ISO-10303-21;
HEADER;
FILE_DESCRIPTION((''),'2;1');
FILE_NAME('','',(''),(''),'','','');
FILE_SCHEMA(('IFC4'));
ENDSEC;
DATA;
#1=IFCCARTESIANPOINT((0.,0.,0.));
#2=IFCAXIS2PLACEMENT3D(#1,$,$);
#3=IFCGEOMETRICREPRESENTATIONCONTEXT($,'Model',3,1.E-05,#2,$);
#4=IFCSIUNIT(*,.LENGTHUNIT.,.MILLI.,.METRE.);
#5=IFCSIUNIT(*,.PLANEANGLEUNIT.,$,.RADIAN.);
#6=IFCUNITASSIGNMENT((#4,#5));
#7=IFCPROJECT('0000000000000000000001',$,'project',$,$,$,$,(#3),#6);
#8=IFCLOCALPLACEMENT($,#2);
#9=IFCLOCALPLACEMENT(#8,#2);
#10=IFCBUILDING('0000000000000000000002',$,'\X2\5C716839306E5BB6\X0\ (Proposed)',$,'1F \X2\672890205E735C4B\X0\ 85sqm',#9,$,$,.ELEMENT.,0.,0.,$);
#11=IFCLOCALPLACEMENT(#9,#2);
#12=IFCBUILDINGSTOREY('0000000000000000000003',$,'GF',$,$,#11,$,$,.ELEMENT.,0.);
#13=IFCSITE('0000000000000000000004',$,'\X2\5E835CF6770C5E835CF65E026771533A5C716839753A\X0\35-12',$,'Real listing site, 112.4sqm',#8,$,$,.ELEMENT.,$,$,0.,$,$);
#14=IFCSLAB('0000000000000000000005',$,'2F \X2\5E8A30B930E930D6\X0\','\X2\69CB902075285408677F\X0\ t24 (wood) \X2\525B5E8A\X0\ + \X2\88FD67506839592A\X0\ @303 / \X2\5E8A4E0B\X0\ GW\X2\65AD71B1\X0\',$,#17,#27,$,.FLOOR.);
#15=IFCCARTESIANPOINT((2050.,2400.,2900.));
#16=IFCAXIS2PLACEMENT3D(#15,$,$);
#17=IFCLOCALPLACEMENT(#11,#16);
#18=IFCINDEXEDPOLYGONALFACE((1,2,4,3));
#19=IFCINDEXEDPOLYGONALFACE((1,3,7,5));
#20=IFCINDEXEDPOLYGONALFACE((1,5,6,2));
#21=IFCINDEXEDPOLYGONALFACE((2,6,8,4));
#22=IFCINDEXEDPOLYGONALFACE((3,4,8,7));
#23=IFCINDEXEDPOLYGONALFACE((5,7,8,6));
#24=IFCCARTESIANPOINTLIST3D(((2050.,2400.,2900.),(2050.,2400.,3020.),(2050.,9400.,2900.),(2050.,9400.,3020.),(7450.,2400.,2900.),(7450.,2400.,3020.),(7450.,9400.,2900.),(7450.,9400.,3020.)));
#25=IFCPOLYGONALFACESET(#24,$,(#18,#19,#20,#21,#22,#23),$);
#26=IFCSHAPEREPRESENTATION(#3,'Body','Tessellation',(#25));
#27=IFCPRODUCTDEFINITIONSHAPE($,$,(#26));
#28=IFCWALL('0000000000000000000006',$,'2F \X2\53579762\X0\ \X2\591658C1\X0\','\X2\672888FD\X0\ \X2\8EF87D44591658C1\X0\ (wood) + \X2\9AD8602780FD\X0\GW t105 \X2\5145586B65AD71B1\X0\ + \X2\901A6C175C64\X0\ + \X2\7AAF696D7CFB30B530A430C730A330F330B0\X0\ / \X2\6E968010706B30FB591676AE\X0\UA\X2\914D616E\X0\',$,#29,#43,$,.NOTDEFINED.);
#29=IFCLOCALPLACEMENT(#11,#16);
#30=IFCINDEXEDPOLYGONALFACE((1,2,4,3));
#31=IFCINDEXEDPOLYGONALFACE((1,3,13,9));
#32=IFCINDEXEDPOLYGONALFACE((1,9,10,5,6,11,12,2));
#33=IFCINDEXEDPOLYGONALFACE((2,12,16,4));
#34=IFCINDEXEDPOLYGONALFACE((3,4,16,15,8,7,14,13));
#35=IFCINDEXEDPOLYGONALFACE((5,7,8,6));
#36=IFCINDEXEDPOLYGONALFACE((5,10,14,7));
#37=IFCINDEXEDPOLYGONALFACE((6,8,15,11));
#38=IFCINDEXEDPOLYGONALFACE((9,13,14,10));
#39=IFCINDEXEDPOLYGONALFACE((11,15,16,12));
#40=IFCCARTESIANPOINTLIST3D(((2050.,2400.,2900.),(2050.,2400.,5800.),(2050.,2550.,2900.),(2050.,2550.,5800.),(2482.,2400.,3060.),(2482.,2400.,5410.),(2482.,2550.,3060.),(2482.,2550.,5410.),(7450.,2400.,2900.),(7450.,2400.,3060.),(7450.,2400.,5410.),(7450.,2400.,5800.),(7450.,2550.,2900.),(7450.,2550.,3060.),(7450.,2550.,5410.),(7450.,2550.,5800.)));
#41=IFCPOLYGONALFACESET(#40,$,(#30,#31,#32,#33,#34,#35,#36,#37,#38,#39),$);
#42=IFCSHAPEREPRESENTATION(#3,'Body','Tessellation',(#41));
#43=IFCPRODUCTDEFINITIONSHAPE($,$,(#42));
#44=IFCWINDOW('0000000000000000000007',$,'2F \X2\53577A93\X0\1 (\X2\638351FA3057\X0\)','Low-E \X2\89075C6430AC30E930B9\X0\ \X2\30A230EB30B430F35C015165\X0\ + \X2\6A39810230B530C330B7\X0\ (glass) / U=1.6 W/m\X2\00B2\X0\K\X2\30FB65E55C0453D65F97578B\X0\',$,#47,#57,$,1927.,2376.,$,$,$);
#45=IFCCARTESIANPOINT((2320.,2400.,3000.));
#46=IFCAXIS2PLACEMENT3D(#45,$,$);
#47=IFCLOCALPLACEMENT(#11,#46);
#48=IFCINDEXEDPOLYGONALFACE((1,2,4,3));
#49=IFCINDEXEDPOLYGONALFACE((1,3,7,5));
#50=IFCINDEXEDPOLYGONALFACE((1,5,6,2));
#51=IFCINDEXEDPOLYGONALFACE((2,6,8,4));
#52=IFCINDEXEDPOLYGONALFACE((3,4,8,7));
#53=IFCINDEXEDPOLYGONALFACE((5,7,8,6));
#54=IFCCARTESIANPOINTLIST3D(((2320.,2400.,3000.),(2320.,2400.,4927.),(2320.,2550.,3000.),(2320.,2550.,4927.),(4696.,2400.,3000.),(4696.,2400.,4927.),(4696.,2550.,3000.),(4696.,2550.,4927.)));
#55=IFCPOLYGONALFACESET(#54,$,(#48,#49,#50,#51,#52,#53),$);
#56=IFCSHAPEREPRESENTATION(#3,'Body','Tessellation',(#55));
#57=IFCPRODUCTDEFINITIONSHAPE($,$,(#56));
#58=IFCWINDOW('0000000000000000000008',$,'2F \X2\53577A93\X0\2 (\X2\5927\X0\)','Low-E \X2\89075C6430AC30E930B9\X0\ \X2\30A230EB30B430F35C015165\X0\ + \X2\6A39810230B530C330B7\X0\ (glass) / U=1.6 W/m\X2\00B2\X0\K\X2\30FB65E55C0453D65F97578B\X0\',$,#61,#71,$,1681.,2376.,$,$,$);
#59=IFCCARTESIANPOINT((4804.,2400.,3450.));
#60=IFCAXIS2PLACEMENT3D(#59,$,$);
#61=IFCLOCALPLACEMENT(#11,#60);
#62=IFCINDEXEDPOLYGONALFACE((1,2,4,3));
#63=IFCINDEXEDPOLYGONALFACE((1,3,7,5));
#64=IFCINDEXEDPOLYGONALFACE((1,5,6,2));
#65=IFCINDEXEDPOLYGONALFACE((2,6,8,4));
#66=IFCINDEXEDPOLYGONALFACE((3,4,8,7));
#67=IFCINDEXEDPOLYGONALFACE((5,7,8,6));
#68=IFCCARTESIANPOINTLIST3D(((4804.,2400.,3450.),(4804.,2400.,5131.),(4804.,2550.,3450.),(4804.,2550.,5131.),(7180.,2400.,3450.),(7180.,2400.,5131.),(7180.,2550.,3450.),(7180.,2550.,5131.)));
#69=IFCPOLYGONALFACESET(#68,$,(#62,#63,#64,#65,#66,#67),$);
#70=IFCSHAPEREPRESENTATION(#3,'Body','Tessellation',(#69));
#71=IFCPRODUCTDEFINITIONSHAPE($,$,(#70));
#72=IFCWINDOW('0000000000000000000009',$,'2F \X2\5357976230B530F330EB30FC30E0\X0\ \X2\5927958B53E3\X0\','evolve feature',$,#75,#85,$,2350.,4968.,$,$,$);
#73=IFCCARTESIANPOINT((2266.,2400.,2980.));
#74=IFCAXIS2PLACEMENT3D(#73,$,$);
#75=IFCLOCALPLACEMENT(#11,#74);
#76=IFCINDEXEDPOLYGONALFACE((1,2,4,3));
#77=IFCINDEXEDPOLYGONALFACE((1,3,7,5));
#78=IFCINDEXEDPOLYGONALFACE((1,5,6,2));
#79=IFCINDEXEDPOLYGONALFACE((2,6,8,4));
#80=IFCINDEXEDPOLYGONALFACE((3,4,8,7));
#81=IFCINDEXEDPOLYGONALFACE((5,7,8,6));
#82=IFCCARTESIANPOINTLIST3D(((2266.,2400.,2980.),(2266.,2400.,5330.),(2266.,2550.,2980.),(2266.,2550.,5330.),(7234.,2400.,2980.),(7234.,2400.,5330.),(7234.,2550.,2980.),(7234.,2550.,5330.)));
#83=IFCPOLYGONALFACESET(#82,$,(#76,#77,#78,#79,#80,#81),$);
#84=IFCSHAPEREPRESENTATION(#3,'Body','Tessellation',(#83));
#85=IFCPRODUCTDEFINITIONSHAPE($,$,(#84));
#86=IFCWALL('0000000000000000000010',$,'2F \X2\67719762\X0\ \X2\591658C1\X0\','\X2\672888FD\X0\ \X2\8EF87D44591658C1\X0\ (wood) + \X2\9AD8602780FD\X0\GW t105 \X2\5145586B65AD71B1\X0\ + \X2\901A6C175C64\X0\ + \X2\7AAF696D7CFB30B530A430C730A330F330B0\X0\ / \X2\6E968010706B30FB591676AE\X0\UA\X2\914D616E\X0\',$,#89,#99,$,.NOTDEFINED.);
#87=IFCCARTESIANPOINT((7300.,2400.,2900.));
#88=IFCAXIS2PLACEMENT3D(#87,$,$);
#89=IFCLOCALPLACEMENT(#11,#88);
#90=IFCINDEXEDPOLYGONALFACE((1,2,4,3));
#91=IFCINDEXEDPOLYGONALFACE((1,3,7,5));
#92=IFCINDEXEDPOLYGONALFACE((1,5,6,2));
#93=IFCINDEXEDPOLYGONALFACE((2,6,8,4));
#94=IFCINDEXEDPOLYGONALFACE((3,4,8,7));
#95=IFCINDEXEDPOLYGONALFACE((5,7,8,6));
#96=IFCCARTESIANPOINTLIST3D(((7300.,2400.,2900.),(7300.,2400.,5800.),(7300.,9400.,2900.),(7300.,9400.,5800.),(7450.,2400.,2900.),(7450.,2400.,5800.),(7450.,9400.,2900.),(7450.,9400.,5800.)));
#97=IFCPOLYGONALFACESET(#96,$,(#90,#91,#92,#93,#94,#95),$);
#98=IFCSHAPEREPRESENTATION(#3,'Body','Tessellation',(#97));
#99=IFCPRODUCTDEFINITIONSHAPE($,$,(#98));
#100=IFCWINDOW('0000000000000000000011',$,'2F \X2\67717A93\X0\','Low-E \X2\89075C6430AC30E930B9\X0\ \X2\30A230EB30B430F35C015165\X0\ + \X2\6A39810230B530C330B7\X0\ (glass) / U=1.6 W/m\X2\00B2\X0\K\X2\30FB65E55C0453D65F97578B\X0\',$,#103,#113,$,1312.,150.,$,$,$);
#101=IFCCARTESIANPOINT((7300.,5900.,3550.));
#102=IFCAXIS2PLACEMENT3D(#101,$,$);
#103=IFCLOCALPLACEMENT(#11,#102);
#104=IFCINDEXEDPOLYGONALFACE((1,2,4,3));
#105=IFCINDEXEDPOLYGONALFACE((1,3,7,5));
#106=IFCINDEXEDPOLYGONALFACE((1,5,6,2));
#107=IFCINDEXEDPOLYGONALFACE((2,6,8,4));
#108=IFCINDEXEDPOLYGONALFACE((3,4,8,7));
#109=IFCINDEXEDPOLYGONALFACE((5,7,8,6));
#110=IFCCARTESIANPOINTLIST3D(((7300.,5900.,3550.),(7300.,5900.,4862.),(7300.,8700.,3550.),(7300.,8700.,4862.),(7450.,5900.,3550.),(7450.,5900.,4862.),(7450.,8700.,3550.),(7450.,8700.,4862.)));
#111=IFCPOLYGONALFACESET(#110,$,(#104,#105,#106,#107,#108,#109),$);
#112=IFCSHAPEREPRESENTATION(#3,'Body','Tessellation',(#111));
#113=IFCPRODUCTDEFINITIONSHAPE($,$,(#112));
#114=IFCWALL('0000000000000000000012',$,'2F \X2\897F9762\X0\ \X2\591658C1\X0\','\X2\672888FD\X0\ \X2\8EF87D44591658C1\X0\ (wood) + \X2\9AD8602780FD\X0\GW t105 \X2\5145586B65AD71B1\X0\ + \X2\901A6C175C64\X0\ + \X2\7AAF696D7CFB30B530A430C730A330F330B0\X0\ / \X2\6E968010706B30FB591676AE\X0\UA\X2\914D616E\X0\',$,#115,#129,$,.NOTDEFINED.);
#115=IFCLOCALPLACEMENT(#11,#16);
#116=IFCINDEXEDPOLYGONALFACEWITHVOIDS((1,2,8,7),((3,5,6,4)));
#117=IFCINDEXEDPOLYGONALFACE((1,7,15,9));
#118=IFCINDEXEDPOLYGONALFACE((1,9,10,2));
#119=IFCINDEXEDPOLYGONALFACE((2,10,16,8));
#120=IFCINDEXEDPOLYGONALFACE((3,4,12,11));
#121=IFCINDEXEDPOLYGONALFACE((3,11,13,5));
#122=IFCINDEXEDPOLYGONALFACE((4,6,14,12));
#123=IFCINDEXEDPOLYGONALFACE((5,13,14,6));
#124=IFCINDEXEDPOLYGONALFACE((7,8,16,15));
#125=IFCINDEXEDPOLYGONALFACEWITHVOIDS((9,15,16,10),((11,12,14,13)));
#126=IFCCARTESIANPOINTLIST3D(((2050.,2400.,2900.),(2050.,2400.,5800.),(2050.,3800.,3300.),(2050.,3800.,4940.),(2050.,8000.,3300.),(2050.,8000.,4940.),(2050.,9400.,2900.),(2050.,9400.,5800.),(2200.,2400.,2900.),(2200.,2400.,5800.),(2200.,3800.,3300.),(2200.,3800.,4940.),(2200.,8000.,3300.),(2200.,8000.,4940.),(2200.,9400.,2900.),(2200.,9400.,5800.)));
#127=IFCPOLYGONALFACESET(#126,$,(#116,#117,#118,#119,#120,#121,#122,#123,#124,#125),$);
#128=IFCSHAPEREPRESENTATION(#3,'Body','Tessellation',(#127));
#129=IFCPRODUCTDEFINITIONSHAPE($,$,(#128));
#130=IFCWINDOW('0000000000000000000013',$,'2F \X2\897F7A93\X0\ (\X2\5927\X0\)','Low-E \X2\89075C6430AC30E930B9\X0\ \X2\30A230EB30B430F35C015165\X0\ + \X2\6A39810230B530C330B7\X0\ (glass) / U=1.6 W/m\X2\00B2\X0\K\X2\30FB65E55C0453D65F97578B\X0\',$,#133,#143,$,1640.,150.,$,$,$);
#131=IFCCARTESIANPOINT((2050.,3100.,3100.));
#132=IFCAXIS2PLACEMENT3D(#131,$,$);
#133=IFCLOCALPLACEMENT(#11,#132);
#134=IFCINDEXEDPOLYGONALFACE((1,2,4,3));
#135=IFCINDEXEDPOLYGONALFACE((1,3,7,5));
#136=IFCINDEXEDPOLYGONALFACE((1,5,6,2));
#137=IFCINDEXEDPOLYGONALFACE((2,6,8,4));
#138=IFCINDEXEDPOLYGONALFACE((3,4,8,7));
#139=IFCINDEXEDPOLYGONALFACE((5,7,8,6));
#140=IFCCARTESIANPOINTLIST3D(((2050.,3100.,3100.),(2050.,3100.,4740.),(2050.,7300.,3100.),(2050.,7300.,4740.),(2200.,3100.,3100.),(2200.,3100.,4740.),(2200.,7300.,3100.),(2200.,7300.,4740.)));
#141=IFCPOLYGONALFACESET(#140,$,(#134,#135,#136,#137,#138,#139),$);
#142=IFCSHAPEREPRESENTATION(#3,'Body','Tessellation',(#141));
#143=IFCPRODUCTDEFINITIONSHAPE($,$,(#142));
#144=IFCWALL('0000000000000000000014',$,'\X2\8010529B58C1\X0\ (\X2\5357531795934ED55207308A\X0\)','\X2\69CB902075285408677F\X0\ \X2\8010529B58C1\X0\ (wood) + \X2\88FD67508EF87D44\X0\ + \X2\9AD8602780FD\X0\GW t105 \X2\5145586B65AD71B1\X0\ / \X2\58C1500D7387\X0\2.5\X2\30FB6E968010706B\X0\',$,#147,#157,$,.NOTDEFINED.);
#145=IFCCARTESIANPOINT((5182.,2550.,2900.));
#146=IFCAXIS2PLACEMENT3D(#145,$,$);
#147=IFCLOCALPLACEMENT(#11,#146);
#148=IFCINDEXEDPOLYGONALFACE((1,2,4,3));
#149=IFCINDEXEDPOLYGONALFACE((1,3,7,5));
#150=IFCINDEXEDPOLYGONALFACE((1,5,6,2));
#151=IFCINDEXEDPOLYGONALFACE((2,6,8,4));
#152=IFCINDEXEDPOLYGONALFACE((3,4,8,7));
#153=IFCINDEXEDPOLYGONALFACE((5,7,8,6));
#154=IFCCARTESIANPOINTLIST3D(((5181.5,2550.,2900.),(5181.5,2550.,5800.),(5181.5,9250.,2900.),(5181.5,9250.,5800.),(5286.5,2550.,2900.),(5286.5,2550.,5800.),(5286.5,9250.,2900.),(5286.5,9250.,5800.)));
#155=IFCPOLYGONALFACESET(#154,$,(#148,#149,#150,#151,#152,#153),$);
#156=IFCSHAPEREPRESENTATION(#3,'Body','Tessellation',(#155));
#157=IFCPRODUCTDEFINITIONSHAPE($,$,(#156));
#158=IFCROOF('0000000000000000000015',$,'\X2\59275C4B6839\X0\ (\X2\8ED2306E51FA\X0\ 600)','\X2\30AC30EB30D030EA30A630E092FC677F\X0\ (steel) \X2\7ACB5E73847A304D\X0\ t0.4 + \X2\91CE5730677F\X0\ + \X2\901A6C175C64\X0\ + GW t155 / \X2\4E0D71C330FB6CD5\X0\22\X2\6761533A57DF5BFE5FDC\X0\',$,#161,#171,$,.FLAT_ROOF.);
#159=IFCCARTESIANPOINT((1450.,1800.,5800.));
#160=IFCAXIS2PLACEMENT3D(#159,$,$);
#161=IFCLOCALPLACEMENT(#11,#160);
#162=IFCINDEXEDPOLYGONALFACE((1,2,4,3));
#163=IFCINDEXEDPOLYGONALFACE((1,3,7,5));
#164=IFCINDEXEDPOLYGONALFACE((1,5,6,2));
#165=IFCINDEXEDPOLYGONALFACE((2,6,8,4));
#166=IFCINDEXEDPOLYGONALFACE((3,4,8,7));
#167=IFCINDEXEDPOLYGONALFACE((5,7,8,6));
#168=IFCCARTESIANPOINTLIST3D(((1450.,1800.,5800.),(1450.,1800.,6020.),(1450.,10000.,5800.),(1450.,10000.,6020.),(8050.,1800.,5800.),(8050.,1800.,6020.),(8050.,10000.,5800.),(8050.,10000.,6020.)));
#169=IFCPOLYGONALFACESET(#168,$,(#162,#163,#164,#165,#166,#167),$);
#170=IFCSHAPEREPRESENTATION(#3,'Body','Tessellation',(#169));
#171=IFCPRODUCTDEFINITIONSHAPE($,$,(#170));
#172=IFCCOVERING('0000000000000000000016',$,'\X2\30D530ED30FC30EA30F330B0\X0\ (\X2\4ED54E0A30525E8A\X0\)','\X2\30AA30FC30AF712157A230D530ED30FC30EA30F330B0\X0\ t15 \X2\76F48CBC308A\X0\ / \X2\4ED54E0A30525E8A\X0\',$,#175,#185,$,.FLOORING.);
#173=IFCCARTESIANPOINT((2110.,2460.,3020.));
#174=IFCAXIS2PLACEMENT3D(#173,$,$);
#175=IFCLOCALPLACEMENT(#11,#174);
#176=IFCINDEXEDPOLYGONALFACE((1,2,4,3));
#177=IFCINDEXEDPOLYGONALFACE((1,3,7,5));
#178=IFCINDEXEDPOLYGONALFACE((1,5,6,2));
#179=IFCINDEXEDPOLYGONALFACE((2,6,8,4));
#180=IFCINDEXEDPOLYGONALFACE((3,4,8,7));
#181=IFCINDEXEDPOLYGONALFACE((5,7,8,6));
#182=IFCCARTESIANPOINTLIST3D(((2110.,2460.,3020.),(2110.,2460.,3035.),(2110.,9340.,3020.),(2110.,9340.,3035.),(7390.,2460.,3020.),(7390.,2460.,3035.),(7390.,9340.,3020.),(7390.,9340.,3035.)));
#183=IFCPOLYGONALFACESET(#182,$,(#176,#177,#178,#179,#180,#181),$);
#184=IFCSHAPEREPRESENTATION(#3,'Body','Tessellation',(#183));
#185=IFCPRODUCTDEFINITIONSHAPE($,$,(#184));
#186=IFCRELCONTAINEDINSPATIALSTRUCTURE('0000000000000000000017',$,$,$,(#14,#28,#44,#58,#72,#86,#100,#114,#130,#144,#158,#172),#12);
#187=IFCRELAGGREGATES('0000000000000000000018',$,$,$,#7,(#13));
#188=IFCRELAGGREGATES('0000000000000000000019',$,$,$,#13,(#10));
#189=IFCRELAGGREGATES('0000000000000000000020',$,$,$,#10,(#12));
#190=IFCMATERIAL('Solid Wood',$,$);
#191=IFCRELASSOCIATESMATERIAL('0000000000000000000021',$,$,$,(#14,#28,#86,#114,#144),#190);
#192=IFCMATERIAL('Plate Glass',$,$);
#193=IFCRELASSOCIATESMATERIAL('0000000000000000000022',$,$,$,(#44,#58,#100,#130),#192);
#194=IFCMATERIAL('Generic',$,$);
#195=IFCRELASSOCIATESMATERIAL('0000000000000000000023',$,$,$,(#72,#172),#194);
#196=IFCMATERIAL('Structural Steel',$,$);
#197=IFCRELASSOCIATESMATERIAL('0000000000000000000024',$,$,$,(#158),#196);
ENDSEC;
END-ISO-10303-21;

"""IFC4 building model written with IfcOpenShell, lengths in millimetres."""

from ifc_helpers import new_model, si_unit, frame, frame_2d, origin, place, context, project, spatial, rectangle, extrude, material, element, fill, save


model = new_model("IFC4")

# Units and contexts
model_context = context("Model", 3, precision=1e-05, world=origin())
ifc_project = project(units=[si_unit("LENGTHUNIT", "METRE", prefix="MILLI"), si_unit("PLANEANGLEUNIT", "RADIAN")], contexts=[model_context])

# Site, building, storey
site_placement = place(None, origin())
site = spatial("IfcSite", under=ifc_project, at=site_placement, Name="広島県広島市東区山根町35-12", ObjectType="Real listing site, 112.4sqm", CompositionType="ELEMENT", RefElevation=0.0)
building_placement = place(site_placement, origin())
building = spatial("IfcBuilding", under=site, at=building_placement, Name="山根の家 (Proposed)", ObjectType="1F 木造平屋 85sqm", CompositionType="ELEMENT", ElevationOfRefHeight=0.0, ElevationOfTerrain=0.0)
storey_placement = place(building_placement, origin())
storey = spatial("IfcBuildingStorey", under=building, at=storey_placement, Name="GF", CompositionType="ELEMENT", Elevation=0.0)

# Slab
ifc_material_1 = material(Name="Solid Wood")
slab_placement = place(storey_placement, frame((2050.0, 2400.0, 2900.0)))
element("IfcSlab", 1, at=slab_placement, inside=storey, material=ifc_material_1, Name="2F 床スラブ", Description="構造用合板 t24 (wood) 剛床 + 製材根太 @303 / 床下 GW断熱", PredefinedType="FLOOR", context=model_context, shape_type="SweptSolid", body=[
    extrude(rectangle(XDim=5400.0, YDim=7000.0, at=frame_2d((2700.0, 3500.0))), frame((2050.0, 2400.0, 2900.0)), (0.0, 0.0, 1.0), 120.0),
])

# Wall, openings, windows
wall_1_placement = place(storey_placement, frame((2050.0, 2400.0, 2900.0)))
wall_1 = element("IfcWall", 2, at=wall_1_placement, inside=storey, material=ifc_material_1, Name="2F 南面 外壁", Description="木製 軸組外壁 (wood) + 高性能GW t105 充填断熱 + 通気層 + 窯業系サイディング / 準耐火・外皮UA配慮", PredefinedType="NOTDEFINED", context=model_context, shape_type="SweptSolid", body=[
    extrude(rectangle(XDim=5400.0, YDim=150.0, at=frame_2d((2700.0, 75.0))), frame((2050.0, 2400.0, 2900.0)), (0.0, 0.0, 1.0), 2900.0),
])
opening_1_placement = place(storey_placement, frame((2320.0, 2400.0, 3000.0)))
opening_1 = element("IfcOpeningElement", 3, at=opening_1_placement, cuts=wall_1, PredefinedType="NOTDEFINED", context=model_context, shape_type="SweptSolid", body=[
    extrude(rectangle(XDim=2376.0, YDim=150.0, at=frame_2d((1188.0, 75.0))), frame((2320.0, 2400.0, 3000.0)), (0.0, 0.0, 1.0), 1927.0),
])
opening_2_placement = place(storey_placement, frame((4804.0, 2400.0, 3450.0)))
opening_2 = element("IfcOpeningElement", 4, at=opening_2_placement, cuts=wall_1, PredefinedType="NOTDEFINED", context=model_context, shape_type="SweptSolid", body=[
    extrude(rectangle(XDim=2376.0, YDim=150.0, at=frame_2d((1188.0, 75.0))), frame((4804.0, 2400.0, 3450.0)), (0.0, 0.0, 1.0), 1681.0),
])
opening_3_placement = place(storey_placement, frame((2266.0, 2400.0, 2980.0)))
opening_3 = element("IfcOpeningElement", 5, at=opening_3_placement, cuts=wall_1, PredefinedType="NOTDEFINED", context=model_context, shape_type="SweptSolid", body=[
    extrude(rectangle(XDim=4968.0, YDim=150.0, at=frame_2d((2484.0, 75.0))), frame((2266.0, 2400.0, 2980.0)), (0.0, 0.0, 1.0), 2350.0),
])
ifc_material_2 = material(Name="Plate Glass")
window_1_placement = place(storey_placement, frame((2320.0, 2400.0, 3000.0)))
window_1 = element("IfcWindow", 6, at=window_1_placement, inside=storey, material=ifc_material_2, Name="2F 南窓1 (掃出し)", Description="Low-E 複層ガラス アルゴン封入 + 樹脂サッシ (glass) / U=1.6 W/m²K・日射取得型", OverallHeight=1927.0, OverallWidth=2376.0, context=model_context, shape_type="SweptSolid", body=[
    extrude(rectangle(XDim=2376.0, YDim=150.0, at=frame_2d((1188.0, 75.0))), frame((2320.0, 2400.0, 3000.0)), (0.0, 0.0, 1.0), 1927.0),
])
fill(opening_1, window_1)
window_2_placement = place(storey_placement, frame((4804.0, 2400.0, 3450.0)))
window_2 = element("IfcWindow", 7, at=window_2_placement, inside=storey, material=ifc_material_2, Name="2F 南窓2 (大)", Description="Low-E 複層ガラス アルゴン封入 + 樹脂サッシ (glass) / U=1.6 W/m²K・日射取得型", OverallHeight=1681.0, OverallWidth=2376.0, context=model_context, shape_type="SweptSolid", body=[
    extrude(rectangle(XDim=2376.0, YDim=150.0, at=frame_2d((1188.0, 75.0))), frame((4804.0, 2400.0, 3450.0)), (0.0, 0.0, 1.0), 1681.0),
])
fill(opening_2, window_2)
ifc_material_3 = material(Name="Generic")
window_3_placement = place(storey_placement, frame((2266.0, 2400.0, 2980.0)))
window_3 = element("IfcWindow", 8, at=window_3_placement, inside=storey, material=ifc_material_3, Name="2F 南面サンルーム 大開口", Description="evolve feature", OverallHeight=2350.0, OverallWidth=4968.0, context=model_context, shape_type="SweptSolid", body=[
    extrude(rectangle(XDim=4968.0, YDim=150.0, at=frame_2d((2484.0, 75.0))), frame((2266.0, 2400.0, 2980.0)), (0.0, 0.0, 1.0), 2350.0),
])
fill(opening_3, window_3)

# Walls, openings, windows
wall_2_placement = place(storey_placement, frame((7300.0, 2400.0, 2900.0)))
wall_2 = element("IfcWall", 9, at=wall_2_placement, inside=storey, material=ifc_material_1, Name="2F 東面 外壁", Description="木製 軸組外壁 (wood) + 高性能GW t105 充填断熱 + 通気層 + 窯業系サイディング / 準耐火・外皮UA配慮", PredefinedType="NOTDEFINED", context=model_context, shape_type="SweptSolid", body=[
    extrude(rectangle(XDim=150.0, YDim=7000.0, at=frame_2d((75.0, 3500.0))), frame((7300.0, 2400.0, 2900.0)), (0.0, 0.0, 1.0), 2900.0),
])
opening_4_placement = place(storey_placement, frame((7300.0, 5900.0, 3550.0)))
opening_4 = element("IfcOpeningElement", 10, at=opening_4_placement, cuts=wall_2, PredefinedType="NOTDEFINED", context=model_context, shape_type="SweptSolid", body=[
    extrude(rectangle(XDim=150.0, YDim=2800.0, at=frame_2d((75.0, 1400.0))), frame((7300.0, 5900.0, 3550.0)), (0.0, 0.0, 1.0), 1312.0),
])
window_4_placement = place(storey_placement, frame((7300.0, 5900.0, 3550.0)))
window_4 = element("IfcWindow", 11, at=window_4_placement, inside=storey, material=ifc_material_2, Name="2F 東窓", Description="Low-E 複層ガラス アルゴン封入 + 樹脂サッシ (glass) / U=1.6 W/m²K・日射取得型", OverallHeight=1312.0, OverallWidth=150.0, context=model_context, shape_type="SweptSolid", body=[
    extrude(rectangle(XDim=150.0, YDim=2800.0, at=frame_2d((75.0, 1400.0))), frame((7300.0, 5900.0, 3550.0)), (0.0, 0.0, 1.0), 1312.0),
])
fill(opening_4, window_4)
wall_3_placement = place(storey_placement, frame((2050.0, 2400.0, 2900.0)))
wall_3 = element("IfcWall", 12, at=wall_3_placement, inside=storey, material=ifc_material_1, Name="2F 西面 外壁", Description="木製 軸組外壁 (wood) + 高性能GW t105 充填断熱 + 通気層 + 窯業系サイディング / 準耐火・外皮UA配慮", PredefinedType="NOTDEFINED", context=model_context, shape_type="SweptSolid", body=[
    extrude(rectangle(XDim=150.0, YDim=7000.0, at=frame_2d((75.0, 3500.0))), frame((2050.0, 2400.0, 2900.0)), (0.0, 0.0, 1.0), 2900.0),
])
opening_5_placement = place(storey_placement, frame((2050.0, 3100.0, 3100.0)))
opening_5 = element("IfcOpeningElement", 13, at=opening_5_placement, cuts=wall_3, PredefinedType="NOTDEFINED", context=model_context, shape_type="SweptSolid", body=[
    extrude(rectangle(XDim=150.0, YDim=4200.0, at=frame_2d((75.0, 2100.0))), frame((2050.0, 3100.0, 3100.0)), (0.0, 0.0, 1.0), 1640.0),
])
window_5_placement = place(storey_placement, frame((2050.0, 3100.0, 3100.0)))
window_5 = element("IfcWindow", 14, at=window_5_placement, inside=storey, material=ifc_material_2, Name="2F 西窓 (大)", Description="Low-E 複層ガラス アルゴン封入 + 樹脂サッシ (glass) / U=1.6 W/m²K・日射取得型", OverallHeight=1640.0, OverallWidth=150.0, context=model_context, shape_type="SweptSolid", body=[
    extrude(rectangle(XDim=150.0, YDim=4200.0, at=frame_2d((75.0, 2100.0))), frame((2050.0, 3100.0, 3100.0)), (0.0, 0.0, 1.0), 1640.0),
])
fill(opening_5, window_5)

# Wall
wall_4_placement = place(storey_placement, frame((5182.0, 2550.0, 2900.0)))
element("IfcWall", 15, at=wall_4_placement, inside=storey, material=ifc_material_1, Name="耐力壁 (南北間仕切り)", Description="構造用合板 耐力壁 (wood) + 製材軸組 + 高性能GW t105 充填断熱 / 壁倍率2.5・準耐火", PredefinedType="NOTDEFINED", context=model_context, shape_type="SweptSolid", body=[
    extrude(rectangle(XDim=105.0, YDim=6700.0, at=frame_2d((52.0, 3350.0))), frame((5182.0, 2550.0, 2900.0)), (0.0, 0.0, 1.0), 2900.0),
])

# Roof
ifc_material_4 = material(Name="Structural Steel")
roof_placement = place(storey_placement, frame((1450.0, 1800.0, 5800.0)))
element("IfcRoof", 16, at=roof_placement, inside=storey, material=ifc_material_4, Name="大屋根 (軒の出 600)", Description="ガルバリウム鋼板 (steel) 立平葺き t0.4 + 野地板 + 通気層 + GW t155 / 不燃・法22条区域対応", PredefinedType="FLAT_ROOF", context=model_context, shape_type="SweptSolid", body=[
    extrude(rectangle(XDim=6600.0, YDim=8200.0, at=frame_2d((3300.0, 4100.0))), frame((1450.0, 1800.0, 5800.0)), (0.0, 0.0, 1.0), 220.0),
])

# Covering
covering_placement = place(storey_placement, frame((2110.0, 2460.0, 3020.0)))
element("IfcCovering", 17, at=covering_placement, inside=storey, material=ifc_material_3, Name="フローリング (仕上げ床)", Description="オーク無垢フローリング t15 直貼り / 仕上げ床", PredefinedType="FLOORING", context=model_context, shape_type="SweptSolid", body=[
    extrude(rectangle(XDim=5280.0, YDim=6880.0, at=frame_2d((2640.0, 3440.0))), frame((2110.0, 2460.0, 3020.0)), (0.0, 0.0, 1.0), 15.0),
])

save(model, "model.ifc")
